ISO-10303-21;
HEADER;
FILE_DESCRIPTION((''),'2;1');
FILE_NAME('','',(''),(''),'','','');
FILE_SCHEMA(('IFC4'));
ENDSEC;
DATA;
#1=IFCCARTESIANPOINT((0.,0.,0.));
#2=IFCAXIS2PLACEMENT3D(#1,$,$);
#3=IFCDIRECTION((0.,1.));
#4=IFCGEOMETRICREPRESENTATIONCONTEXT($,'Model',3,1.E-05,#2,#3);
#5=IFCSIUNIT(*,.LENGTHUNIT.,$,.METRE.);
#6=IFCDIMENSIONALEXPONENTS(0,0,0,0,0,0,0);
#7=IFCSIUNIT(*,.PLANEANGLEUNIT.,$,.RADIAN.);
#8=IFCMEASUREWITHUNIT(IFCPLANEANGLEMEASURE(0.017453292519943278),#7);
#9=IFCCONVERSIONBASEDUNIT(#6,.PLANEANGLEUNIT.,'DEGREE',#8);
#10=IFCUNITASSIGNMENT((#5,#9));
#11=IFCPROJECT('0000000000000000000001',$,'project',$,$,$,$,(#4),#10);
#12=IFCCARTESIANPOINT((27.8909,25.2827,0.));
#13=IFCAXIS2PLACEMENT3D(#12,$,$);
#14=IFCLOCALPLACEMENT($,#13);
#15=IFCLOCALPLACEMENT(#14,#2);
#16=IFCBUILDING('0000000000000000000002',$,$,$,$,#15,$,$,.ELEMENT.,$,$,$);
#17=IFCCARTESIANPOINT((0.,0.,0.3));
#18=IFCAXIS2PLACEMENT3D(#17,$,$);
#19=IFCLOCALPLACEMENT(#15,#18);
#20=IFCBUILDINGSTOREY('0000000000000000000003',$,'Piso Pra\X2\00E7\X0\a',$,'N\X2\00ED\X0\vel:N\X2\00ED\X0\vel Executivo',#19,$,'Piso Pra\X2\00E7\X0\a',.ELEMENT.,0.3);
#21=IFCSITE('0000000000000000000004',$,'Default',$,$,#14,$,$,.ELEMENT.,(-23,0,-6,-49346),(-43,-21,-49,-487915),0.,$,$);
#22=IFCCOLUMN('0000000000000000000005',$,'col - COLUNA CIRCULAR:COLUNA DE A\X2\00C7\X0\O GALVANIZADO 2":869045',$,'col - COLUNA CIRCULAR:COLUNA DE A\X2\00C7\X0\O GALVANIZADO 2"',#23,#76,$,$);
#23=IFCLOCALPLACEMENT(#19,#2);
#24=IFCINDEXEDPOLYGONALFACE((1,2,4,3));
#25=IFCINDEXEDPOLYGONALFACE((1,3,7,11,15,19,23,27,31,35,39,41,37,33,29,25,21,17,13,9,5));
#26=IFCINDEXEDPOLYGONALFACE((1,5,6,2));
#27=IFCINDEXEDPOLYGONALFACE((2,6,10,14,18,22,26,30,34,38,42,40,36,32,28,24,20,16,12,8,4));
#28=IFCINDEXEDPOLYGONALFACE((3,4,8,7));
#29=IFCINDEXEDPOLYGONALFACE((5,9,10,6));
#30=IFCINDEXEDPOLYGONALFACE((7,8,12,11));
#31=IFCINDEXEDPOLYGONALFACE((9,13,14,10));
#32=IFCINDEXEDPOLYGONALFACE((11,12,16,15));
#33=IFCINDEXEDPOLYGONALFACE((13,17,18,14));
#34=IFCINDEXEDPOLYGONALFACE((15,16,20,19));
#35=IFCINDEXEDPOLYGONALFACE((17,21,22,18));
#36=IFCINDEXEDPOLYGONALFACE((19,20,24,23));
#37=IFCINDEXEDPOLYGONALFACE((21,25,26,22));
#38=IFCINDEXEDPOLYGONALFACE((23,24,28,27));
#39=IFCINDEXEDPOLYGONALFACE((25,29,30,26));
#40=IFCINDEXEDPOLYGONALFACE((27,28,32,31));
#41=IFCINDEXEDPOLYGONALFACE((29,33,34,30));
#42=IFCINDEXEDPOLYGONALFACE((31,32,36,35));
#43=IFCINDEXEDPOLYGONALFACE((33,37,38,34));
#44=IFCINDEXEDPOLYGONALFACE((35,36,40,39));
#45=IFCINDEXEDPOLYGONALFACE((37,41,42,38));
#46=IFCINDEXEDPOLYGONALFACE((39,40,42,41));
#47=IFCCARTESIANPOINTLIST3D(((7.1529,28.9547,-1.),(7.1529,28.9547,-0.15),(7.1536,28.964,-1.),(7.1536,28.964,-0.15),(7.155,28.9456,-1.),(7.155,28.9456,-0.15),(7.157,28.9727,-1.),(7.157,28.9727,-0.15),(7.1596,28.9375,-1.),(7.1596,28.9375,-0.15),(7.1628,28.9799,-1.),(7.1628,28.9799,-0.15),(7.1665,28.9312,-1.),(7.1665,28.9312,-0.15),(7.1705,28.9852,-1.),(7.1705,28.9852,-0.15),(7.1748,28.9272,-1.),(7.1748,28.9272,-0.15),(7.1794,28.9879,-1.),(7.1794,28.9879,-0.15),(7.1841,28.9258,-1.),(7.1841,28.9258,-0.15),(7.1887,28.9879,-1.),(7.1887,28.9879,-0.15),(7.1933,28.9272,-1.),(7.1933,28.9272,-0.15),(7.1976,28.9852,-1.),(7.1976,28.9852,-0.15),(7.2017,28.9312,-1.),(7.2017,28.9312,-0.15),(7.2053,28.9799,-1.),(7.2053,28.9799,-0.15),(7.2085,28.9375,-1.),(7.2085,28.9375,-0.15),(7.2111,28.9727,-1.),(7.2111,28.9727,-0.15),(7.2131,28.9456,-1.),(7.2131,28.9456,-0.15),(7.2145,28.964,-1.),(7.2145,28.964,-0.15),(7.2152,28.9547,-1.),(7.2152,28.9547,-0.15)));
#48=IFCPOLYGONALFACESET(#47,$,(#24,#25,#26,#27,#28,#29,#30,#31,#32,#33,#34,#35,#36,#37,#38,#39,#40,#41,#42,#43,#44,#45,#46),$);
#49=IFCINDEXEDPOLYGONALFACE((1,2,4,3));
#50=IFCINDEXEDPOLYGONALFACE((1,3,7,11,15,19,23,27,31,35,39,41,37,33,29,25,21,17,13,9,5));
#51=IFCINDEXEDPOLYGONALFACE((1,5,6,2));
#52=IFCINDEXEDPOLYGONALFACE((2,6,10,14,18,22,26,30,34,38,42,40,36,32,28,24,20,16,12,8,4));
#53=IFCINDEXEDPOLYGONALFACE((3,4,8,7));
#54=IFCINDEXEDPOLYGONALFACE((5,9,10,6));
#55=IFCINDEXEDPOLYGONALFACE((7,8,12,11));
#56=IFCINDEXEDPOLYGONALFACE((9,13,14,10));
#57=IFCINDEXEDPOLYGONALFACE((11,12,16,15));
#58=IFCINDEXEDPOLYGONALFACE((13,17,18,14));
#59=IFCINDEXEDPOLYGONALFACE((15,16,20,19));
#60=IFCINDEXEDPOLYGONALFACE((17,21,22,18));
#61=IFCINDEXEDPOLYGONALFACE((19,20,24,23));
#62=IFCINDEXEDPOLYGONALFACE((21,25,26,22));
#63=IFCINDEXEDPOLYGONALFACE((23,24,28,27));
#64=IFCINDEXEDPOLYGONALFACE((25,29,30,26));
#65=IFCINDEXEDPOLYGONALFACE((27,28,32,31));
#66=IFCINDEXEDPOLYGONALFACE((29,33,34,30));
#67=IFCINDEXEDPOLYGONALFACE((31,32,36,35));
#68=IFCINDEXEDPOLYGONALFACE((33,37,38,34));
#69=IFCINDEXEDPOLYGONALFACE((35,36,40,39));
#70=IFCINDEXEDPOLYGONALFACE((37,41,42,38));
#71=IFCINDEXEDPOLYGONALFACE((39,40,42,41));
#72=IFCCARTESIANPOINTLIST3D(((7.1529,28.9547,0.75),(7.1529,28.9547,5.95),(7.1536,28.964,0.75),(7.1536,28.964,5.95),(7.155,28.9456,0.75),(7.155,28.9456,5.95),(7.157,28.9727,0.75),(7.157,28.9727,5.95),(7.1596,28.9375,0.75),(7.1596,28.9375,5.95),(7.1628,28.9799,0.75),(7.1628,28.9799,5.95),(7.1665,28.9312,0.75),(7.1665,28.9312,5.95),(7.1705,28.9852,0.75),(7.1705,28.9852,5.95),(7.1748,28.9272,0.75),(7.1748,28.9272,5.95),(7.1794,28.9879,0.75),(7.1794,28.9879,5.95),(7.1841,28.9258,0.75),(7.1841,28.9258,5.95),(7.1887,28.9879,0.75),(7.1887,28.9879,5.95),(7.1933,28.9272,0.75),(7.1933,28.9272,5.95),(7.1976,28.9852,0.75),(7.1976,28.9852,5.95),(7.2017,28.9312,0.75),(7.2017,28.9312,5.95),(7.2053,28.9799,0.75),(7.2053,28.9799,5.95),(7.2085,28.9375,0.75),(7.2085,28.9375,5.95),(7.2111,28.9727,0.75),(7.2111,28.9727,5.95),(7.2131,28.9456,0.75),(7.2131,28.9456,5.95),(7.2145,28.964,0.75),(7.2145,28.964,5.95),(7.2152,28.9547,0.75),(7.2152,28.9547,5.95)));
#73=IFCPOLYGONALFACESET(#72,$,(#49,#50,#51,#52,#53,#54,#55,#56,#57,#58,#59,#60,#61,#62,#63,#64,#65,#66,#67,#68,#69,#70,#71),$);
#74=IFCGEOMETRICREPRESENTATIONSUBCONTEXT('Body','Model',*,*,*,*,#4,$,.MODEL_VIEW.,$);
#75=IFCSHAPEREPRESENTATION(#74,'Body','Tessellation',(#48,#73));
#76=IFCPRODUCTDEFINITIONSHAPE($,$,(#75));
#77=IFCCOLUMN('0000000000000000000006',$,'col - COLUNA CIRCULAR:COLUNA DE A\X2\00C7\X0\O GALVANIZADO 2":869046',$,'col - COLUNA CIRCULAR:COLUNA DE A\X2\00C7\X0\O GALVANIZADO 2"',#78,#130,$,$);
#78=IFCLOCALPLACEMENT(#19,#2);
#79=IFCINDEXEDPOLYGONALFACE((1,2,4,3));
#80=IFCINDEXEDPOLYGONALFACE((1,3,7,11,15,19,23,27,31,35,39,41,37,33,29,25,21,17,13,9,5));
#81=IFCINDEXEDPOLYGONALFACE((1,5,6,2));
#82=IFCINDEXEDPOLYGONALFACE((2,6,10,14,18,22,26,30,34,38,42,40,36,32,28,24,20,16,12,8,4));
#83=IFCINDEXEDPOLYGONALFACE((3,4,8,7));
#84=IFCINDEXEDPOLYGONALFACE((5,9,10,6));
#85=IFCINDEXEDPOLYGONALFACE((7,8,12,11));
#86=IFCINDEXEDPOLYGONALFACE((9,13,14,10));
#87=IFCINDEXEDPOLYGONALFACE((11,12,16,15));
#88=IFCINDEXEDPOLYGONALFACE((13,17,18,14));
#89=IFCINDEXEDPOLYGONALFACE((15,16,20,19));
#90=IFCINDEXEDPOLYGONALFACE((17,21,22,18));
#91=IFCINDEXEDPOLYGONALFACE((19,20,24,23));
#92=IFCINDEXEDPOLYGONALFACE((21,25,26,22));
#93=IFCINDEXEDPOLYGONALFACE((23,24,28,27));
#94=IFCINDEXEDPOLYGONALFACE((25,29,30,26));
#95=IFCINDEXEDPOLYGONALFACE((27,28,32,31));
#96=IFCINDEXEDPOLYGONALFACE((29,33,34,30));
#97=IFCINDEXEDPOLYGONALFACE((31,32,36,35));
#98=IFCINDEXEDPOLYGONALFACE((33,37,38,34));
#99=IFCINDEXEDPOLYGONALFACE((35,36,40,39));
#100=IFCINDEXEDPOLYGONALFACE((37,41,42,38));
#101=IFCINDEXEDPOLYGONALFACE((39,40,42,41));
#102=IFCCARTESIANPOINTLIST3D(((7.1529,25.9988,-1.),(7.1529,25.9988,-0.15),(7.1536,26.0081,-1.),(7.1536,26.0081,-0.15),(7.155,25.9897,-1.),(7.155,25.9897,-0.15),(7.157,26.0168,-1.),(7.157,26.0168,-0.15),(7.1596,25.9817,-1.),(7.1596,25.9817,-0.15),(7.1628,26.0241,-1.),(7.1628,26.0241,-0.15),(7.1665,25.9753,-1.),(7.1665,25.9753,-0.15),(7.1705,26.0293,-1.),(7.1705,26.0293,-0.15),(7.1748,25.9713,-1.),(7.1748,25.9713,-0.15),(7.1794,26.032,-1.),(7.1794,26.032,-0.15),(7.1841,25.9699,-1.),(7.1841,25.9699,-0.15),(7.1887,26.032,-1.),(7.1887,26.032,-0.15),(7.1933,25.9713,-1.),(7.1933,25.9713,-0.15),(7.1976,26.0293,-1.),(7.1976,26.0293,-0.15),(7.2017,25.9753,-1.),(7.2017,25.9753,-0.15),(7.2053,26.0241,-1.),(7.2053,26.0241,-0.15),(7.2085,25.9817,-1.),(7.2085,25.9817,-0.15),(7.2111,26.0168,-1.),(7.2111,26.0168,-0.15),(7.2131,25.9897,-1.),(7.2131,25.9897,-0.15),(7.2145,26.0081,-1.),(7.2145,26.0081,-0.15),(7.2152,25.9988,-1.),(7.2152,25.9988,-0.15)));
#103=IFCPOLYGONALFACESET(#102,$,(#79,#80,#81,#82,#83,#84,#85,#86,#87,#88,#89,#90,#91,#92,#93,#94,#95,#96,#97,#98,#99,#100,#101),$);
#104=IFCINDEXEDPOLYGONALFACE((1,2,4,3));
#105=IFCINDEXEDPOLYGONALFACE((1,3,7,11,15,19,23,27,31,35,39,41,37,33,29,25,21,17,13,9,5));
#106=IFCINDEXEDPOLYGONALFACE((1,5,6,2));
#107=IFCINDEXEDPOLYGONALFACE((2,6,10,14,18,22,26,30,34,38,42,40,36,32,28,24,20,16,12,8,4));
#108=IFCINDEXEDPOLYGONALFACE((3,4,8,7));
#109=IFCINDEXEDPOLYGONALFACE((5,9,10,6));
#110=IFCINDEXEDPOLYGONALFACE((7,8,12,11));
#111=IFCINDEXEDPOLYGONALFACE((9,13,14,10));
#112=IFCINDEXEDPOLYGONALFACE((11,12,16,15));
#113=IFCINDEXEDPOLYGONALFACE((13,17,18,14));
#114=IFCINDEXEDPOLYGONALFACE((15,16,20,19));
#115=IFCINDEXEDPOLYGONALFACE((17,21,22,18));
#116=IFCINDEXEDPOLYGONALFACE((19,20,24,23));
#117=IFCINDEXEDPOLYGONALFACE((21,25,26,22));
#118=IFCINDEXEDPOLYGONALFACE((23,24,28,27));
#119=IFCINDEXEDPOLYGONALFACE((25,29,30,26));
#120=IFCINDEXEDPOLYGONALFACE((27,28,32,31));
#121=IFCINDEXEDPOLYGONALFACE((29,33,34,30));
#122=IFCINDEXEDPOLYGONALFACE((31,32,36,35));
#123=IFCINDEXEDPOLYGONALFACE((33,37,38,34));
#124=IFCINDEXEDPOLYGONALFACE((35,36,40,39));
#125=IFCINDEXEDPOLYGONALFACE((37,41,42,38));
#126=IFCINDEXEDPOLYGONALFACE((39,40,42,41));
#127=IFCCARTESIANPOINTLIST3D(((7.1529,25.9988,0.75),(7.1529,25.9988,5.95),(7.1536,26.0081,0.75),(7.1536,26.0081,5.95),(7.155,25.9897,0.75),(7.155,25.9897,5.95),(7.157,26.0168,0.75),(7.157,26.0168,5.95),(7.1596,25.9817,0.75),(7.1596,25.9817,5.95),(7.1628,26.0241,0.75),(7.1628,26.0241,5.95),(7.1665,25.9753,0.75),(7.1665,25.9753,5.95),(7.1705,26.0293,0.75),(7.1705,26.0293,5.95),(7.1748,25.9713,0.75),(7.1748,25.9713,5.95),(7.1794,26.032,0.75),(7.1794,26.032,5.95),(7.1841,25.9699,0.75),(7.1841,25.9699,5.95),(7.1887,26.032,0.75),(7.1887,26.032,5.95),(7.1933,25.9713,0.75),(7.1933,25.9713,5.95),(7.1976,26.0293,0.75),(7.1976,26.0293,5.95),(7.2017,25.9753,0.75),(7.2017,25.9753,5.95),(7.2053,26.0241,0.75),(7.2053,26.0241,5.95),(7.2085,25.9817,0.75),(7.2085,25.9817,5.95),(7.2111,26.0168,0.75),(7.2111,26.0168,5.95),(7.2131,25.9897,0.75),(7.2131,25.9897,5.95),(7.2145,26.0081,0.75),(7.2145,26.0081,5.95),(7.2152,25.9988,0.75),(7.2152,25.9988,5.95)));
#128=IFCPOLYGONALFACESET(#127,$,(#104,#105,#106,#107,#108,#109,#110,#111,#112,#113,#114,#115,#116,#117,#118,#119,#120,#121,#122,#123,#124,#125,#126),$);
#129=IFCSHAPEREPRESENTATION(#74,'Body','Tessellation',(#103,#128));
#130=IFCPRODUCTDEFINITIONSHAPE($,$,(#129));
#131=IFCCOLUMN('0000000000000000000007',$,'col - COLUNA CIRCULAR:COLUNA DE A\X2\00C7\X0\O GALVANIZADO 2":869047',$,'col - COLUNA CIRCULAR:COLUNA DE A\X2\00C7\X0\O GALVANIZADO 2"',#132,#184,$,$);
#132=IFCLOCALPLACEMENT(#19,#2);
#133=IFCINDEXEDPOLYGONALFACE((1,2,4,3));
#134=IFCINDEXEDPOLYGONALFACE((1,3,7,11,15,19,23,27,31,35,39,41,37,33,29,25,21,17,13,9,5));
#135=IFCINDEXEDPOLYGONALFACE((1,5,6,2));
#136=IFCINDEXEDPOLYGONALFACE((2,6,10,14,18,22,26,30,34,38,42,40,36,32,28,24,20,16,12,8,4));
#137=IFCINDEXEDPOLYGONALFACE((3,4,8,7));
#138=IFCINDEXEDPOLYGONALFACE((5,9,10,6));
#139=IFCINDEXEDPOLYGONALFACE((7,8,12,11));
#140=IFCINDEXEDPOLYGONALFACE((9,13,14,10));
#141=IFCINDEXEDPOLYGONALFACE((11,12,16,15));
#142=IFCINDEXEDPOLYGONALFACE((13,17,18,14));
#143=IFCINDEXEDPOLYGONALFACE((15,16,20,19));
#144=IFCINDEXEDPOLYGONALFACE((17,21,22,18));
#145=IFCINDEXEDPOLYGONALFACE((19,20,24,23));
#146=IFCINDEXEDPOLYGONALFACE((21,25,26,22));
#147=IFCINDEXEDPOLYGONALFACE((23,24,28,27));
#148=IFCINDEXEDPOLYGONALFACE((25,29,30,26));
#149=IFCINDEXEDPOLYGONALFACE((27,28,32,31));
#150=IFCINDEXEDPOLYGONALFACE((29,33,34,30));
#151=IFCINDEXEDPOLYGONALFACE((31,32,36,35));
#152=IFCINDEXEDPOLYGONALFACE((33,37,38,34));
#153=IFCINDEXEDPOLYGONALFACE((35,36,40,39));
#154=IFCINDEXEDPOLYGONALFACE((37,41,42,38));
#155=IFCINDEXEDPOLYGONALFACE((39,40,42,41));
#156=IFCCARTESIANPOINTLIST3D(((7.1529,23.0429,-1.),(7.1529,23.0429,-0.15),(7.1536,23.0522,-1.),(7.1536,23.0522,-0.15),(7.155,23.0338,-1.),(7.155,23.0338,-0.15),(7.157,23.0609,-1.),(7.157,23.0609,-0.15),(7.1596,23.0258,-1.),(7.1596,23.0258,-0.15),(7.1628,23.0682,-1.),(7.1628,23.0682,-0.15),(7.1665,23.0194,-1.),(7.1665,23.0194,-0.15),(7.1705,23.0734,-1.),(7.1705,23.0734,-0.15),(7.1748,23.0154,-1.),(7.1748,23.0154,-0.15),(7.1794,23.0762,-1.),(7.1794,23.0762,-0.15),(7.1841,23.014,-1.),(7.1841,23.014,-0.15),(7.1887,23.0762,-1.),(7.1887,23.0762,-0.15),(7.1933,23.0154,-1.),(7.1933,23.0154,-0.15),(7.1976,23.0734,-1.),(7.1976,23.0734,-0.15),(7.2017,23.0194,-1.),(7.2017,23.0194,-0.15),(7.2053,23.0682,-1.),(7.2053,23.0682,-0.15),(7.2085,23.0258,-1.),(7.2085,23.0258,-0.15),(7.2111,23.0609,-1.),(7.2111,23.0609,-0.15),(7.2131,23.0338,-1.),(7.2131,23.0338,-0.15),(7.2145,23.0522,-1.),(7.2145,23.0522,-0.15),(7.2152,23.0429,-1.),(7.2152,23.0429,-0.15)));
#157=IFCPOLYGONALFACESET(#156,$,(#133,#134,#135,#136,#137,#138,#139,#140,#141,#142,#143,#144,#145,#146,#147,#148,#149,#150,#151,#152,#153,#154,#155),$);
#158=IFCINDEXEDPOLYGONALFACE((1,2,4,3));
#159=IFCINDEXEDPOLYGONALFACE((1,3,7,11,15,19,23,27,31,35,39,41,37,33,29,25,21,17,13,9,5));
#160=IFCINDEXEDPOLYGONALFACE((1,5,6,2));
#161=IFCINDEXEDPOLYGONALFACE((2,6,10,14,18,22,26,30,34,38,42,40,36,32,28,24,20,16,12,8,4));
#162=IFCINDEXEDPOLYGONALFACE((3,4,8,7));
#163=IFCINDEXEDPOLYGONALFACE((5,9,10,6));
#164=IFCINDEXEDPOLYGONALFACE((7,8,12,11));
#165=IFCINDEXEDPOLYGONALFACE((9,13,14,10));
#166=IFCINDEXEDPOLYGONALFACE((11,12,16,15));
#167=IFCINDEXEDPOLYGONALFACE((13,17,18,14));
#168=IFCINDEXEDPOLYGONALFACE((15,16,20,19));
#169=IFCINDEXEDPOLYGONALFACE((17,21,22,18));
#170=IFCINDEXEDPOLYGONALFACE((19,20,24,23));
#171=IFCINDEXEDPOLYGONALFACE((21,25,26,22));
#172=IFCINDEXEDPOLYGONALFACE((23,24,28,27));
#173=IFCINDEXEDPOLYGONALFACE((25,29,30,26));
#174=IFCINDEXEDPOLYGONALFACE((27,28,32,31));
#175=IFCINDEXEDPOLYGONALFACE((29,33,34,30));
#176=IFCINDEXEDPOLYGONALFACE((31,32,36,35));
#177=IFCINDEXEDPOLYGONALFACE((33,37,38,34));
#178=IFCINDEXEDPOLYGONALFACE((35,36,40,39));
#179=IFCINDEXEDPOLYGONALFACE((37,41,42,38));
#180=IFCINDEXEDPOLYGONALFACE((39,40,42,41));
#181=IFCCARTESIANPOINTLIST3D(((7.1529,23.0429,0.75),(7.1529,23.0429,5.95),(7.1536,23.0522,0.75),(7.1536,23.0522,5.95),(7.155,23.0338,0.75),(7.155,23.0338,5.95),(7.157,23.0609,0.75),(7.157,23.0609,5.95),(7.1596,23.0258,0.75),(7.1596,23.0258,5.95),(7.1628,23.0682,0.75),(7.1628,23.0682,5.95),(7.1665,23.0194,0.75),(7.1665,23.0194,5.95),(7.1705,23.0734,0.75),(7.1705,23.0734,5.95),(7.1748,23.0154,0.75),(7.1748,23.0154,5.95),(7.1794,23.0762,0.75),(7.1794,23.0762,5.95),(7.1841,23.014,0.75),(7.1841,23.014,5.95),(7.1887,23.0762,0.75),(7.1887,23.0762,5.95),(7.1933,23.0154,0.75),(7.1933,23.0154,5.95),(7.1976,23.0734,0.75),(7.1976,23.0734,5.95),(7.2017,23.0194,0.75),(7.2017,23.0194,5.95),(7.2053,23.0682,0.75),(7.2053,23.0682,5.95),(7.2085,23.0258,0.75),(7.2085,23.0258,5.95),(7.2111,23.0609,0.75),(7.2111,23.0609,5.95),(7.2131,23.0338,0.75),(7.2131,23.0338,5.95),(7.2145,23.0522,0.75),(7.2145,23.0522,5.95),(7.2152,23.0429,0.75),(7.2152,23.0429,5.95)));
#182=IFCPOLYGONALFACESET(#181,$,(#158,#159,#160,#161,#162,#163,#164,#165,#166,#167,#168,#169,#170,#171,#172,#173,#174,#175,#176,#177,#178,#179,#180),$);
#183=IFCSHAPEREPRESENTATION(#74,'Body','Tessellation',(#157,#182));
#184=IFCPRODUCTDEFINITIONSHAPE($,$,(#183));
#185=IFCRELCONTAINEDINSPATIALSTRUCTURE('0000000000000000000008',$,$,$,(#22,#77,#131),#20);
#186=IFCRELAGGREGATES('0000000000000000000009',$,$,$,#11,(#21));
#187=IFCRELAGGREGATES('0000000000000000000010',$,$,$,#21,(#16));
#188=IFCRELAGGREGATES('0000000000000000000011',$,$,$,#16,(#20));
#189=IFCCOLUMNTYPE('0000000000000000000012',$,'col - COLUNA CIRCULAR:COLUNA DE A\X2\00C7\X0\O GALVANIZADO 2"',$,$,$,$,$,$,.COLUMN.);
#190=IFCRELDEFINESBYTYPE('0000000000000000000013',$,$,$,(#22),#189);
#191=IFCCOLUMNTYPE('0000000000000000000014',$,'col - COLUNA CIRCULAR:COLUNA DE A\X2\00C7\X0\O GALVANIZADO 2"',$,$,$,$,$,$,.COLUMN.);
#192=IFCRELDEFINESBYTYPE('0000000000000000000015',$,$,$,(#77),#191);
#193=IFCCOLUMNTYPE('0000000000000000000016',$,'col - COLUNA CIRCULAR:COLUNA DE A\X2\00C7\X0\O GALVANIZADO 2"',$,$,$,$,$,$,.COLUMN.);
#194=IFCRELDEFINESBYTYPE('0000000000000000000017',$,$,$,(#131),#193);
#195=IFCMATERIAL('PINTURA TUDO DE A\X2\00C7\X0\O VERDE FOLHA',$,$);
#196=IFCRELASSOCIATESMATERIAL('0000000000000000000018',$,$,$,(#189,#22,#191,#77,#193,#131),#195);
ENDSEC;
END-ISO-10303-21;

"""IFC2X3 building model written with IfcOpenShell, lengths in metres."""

from ifc_helpers import new_model, entity, si_unit, converted_unit, direction, frame, origin, origin_2d_with_axis, place, context, subcontext, project, spatial, circle, extrude, source, transform, mapped, material, type_object, type_shapes, element, save


model = new_model("IFC2X3")

# Units and contexts
model_context = context("Model", 3, precision=1e-05, world=origin(), true_north=direction((0.0, 1.0)))
body_context = subcontext(model_context, "Body", "Model", "MODEL_VIEW")
ifc_project = project(units=[si_unit("LENGTHUNIT", "METRE"), converted_unit("PLANEANGLEUNIT", "DEGREE", entity("IfcPlaneAngleMeasure", 0.017453292519943278), si_unit("PLANEANGLEUNIT", "RADIAN"), dimensions=[0, 0, 0, 0, 0, 0, 0])], contexts=[model_context])

# Site, building, storey
site_placement = place(None, frame((27.8909, 25.2827, 0.0)))
site = spatial("IfcSite", under=ifc_project, at=site_placement, Name="Default", CompositionType="ELEMENT", RefLatitude=(-23, 0, -6, -49346), RefLongitude=(-43, -21, -49, -487915), RefElevation=0.0)
building_placement = place(site_placement, origin())
building = spatial("IfcBuilding", under=site, at=building_placement, CompositionType="ELEMENT")
storey_placement = place(building_placement, frame((0.0, 0.0, 0.3)))
storey = spatial("IfcBuildingStorey", under=building, at=storey_placement, Name="Piso Praça", ObjectType="Nível:Nível Executivo", LongName="Piso Praça", CompositionType="ELEMENT", Elevation=0.3)

# Columns
ifc_material = material(Name="PINTURA TUDO DE AÇO VERDE FOLHA")
column_type_1 = type_object("IfcColumnType", Name="col - COLUNA CIRCULAR:COLUNA DE AÇO GALVANIZADO 2\"", PredefinedType="COLUMN", material=ifc_material)
shared_shape_1 = source(origin(), body_context, "Body", "SweptSolid", [
    extrude(circle(Radius=0.0312, at=origin_2d_with_axis()), frame((7.1841, 28.957, -0.7), z_axis=(0.0, 0.0, 1.0), x_axis=(0.0, -1.0, 0.0)), (0.0, 0.0, 1.0), 0.85),
    extrude(circle(Radius=0.0312, at=origin_2d_with_axis()), frame((7.1841, 28.957, 1.05), z_axis=(0.0, 0.0, 1.0), x_axis=(0.0, -1.0, 0.0)), (0.0, 0.0, 1.0), 5.2),
])
type_shapes(column_type_1, [shared_shape_1])
column_1_placement = place(storey_placement, frame((0.0, 0.0, -0.3)))
element("IfcColumn", 1, at=column_1_placement, inside=storey, type_object=column_type_1, material=ifc_material, Name="col - COLUNA CIRCULAR:COLUNA DE AÇO GALVANIZADO 2\":869045", ObjectType="col - COLUNA CIRCULAR:COLUNA DE AÇO GALVANIZADO 2\"", context=body_context, shape_type="MappedRepresentation", body=[
    mapped(shared_shape_1, transform((0.0, 0.0, 0.0), scale=1.0)),
])
column_type_2 = type_object("IfcColumnType", Name="col - COLUNA CIRCULAR:COLUNA DE AÇO GALVANIZADO 2\"", PredefinedType="COLUMN", material=ifc_material)
shared_shape_2 = source(origin(), body_context, "Body", "SweptSolid", [
    extrude(circle(Radius=0.0312, at=origin_2d_with_axis()), frame((7.1841, 26.0011, -0.7), z_axis=(0.0, 0.0, 1.0), x_axis=(0.0, -1.0, 0.0)), (0.0, 0.0, 1.0), 0.85),
    extrude(circle(Radius=0.0312, at=origin_2d_with_axis()), frame((7.1841, 26.0011, 1.05), z_axis=(0.0, 0.0, 1.0), x_axis=(0.0, -1.0, 0.0)), (0.0, 0.0, 1.0), 5.2),
])
type_shapes(column_type_2, [shared_shape_2])
column_2_placement = place(storey_placement, frame((0.0, 0.0, -0.3)))
element("IfcColumn", 2, at=column_2_placement, inside=storey, type_object=column_type_2, material=ifc_material, Name="col - COLUNA CIRCULAR:COLUNA DE AÇO GALVANIZADO 2\":869046", ObjectType="col - COLUNA CIRCULAR:COLUNA DE AÇO GALVANIZADO 2\"", context=body_context, shape_type="MappedRepresentation", body=[
    mapped(shared_shape_2, transform((0.0, 0.0, 0.0), scale=1.0)),
])
column_type_3 = type_object("IfcColumnType", Name="col - COLUNA CIRCULAR:COLUNA DE AÇO GALVANIZADO 2\"", PredefinedType="COLUMN", material=ifc_material)
shared_shape_3 = source(origin(), body_context, "Body", "SweptSolid", [
    extrude(circle(Radius=0.0312, at=origin_2d_with_axis()), frame((7.1841, 23.0453, -0.7), z_axis=(0.0, 0.0, 1.0), x_axis=(0.0, -1.0, 0.0)), (0.0, 0.0, 1.0), 0.85),
    extrude(circle(Radius=0.0312, at=origin_2d_with_axis()), frame((7.1841, 23.0453, 1.05), z_axis=(0.0, 0.0, 1.0), x_axis=(0.0, -1.0, 0.0)), (0.0, 0.0, 1.0), 5.2),
])
type_shapes(column_type_3, [shared_shape_3])
column_3_placement = place(storey_placement, frame((0.0, 0.0, -0.3)))
element("IfcColumn", 3, at=column_3_placement, inside=storey, type_object=column_type_3, material=ifc_material, Name="col - COLUNA CIRCULAR:COLUNA DE AÇO GALVANIZADO 2\":869047", ObjectType="col - COLUNA CIRCULAR:COLUNA DE AÇO GALVANIZADO 2\"", context=body_context, shape_type="MappedRepresentation", body=[
    mapped(shared_shape_3, transform((0.0, 0.0, 0.0), scale=1.0)),
])

save(model, "model.ifc")
